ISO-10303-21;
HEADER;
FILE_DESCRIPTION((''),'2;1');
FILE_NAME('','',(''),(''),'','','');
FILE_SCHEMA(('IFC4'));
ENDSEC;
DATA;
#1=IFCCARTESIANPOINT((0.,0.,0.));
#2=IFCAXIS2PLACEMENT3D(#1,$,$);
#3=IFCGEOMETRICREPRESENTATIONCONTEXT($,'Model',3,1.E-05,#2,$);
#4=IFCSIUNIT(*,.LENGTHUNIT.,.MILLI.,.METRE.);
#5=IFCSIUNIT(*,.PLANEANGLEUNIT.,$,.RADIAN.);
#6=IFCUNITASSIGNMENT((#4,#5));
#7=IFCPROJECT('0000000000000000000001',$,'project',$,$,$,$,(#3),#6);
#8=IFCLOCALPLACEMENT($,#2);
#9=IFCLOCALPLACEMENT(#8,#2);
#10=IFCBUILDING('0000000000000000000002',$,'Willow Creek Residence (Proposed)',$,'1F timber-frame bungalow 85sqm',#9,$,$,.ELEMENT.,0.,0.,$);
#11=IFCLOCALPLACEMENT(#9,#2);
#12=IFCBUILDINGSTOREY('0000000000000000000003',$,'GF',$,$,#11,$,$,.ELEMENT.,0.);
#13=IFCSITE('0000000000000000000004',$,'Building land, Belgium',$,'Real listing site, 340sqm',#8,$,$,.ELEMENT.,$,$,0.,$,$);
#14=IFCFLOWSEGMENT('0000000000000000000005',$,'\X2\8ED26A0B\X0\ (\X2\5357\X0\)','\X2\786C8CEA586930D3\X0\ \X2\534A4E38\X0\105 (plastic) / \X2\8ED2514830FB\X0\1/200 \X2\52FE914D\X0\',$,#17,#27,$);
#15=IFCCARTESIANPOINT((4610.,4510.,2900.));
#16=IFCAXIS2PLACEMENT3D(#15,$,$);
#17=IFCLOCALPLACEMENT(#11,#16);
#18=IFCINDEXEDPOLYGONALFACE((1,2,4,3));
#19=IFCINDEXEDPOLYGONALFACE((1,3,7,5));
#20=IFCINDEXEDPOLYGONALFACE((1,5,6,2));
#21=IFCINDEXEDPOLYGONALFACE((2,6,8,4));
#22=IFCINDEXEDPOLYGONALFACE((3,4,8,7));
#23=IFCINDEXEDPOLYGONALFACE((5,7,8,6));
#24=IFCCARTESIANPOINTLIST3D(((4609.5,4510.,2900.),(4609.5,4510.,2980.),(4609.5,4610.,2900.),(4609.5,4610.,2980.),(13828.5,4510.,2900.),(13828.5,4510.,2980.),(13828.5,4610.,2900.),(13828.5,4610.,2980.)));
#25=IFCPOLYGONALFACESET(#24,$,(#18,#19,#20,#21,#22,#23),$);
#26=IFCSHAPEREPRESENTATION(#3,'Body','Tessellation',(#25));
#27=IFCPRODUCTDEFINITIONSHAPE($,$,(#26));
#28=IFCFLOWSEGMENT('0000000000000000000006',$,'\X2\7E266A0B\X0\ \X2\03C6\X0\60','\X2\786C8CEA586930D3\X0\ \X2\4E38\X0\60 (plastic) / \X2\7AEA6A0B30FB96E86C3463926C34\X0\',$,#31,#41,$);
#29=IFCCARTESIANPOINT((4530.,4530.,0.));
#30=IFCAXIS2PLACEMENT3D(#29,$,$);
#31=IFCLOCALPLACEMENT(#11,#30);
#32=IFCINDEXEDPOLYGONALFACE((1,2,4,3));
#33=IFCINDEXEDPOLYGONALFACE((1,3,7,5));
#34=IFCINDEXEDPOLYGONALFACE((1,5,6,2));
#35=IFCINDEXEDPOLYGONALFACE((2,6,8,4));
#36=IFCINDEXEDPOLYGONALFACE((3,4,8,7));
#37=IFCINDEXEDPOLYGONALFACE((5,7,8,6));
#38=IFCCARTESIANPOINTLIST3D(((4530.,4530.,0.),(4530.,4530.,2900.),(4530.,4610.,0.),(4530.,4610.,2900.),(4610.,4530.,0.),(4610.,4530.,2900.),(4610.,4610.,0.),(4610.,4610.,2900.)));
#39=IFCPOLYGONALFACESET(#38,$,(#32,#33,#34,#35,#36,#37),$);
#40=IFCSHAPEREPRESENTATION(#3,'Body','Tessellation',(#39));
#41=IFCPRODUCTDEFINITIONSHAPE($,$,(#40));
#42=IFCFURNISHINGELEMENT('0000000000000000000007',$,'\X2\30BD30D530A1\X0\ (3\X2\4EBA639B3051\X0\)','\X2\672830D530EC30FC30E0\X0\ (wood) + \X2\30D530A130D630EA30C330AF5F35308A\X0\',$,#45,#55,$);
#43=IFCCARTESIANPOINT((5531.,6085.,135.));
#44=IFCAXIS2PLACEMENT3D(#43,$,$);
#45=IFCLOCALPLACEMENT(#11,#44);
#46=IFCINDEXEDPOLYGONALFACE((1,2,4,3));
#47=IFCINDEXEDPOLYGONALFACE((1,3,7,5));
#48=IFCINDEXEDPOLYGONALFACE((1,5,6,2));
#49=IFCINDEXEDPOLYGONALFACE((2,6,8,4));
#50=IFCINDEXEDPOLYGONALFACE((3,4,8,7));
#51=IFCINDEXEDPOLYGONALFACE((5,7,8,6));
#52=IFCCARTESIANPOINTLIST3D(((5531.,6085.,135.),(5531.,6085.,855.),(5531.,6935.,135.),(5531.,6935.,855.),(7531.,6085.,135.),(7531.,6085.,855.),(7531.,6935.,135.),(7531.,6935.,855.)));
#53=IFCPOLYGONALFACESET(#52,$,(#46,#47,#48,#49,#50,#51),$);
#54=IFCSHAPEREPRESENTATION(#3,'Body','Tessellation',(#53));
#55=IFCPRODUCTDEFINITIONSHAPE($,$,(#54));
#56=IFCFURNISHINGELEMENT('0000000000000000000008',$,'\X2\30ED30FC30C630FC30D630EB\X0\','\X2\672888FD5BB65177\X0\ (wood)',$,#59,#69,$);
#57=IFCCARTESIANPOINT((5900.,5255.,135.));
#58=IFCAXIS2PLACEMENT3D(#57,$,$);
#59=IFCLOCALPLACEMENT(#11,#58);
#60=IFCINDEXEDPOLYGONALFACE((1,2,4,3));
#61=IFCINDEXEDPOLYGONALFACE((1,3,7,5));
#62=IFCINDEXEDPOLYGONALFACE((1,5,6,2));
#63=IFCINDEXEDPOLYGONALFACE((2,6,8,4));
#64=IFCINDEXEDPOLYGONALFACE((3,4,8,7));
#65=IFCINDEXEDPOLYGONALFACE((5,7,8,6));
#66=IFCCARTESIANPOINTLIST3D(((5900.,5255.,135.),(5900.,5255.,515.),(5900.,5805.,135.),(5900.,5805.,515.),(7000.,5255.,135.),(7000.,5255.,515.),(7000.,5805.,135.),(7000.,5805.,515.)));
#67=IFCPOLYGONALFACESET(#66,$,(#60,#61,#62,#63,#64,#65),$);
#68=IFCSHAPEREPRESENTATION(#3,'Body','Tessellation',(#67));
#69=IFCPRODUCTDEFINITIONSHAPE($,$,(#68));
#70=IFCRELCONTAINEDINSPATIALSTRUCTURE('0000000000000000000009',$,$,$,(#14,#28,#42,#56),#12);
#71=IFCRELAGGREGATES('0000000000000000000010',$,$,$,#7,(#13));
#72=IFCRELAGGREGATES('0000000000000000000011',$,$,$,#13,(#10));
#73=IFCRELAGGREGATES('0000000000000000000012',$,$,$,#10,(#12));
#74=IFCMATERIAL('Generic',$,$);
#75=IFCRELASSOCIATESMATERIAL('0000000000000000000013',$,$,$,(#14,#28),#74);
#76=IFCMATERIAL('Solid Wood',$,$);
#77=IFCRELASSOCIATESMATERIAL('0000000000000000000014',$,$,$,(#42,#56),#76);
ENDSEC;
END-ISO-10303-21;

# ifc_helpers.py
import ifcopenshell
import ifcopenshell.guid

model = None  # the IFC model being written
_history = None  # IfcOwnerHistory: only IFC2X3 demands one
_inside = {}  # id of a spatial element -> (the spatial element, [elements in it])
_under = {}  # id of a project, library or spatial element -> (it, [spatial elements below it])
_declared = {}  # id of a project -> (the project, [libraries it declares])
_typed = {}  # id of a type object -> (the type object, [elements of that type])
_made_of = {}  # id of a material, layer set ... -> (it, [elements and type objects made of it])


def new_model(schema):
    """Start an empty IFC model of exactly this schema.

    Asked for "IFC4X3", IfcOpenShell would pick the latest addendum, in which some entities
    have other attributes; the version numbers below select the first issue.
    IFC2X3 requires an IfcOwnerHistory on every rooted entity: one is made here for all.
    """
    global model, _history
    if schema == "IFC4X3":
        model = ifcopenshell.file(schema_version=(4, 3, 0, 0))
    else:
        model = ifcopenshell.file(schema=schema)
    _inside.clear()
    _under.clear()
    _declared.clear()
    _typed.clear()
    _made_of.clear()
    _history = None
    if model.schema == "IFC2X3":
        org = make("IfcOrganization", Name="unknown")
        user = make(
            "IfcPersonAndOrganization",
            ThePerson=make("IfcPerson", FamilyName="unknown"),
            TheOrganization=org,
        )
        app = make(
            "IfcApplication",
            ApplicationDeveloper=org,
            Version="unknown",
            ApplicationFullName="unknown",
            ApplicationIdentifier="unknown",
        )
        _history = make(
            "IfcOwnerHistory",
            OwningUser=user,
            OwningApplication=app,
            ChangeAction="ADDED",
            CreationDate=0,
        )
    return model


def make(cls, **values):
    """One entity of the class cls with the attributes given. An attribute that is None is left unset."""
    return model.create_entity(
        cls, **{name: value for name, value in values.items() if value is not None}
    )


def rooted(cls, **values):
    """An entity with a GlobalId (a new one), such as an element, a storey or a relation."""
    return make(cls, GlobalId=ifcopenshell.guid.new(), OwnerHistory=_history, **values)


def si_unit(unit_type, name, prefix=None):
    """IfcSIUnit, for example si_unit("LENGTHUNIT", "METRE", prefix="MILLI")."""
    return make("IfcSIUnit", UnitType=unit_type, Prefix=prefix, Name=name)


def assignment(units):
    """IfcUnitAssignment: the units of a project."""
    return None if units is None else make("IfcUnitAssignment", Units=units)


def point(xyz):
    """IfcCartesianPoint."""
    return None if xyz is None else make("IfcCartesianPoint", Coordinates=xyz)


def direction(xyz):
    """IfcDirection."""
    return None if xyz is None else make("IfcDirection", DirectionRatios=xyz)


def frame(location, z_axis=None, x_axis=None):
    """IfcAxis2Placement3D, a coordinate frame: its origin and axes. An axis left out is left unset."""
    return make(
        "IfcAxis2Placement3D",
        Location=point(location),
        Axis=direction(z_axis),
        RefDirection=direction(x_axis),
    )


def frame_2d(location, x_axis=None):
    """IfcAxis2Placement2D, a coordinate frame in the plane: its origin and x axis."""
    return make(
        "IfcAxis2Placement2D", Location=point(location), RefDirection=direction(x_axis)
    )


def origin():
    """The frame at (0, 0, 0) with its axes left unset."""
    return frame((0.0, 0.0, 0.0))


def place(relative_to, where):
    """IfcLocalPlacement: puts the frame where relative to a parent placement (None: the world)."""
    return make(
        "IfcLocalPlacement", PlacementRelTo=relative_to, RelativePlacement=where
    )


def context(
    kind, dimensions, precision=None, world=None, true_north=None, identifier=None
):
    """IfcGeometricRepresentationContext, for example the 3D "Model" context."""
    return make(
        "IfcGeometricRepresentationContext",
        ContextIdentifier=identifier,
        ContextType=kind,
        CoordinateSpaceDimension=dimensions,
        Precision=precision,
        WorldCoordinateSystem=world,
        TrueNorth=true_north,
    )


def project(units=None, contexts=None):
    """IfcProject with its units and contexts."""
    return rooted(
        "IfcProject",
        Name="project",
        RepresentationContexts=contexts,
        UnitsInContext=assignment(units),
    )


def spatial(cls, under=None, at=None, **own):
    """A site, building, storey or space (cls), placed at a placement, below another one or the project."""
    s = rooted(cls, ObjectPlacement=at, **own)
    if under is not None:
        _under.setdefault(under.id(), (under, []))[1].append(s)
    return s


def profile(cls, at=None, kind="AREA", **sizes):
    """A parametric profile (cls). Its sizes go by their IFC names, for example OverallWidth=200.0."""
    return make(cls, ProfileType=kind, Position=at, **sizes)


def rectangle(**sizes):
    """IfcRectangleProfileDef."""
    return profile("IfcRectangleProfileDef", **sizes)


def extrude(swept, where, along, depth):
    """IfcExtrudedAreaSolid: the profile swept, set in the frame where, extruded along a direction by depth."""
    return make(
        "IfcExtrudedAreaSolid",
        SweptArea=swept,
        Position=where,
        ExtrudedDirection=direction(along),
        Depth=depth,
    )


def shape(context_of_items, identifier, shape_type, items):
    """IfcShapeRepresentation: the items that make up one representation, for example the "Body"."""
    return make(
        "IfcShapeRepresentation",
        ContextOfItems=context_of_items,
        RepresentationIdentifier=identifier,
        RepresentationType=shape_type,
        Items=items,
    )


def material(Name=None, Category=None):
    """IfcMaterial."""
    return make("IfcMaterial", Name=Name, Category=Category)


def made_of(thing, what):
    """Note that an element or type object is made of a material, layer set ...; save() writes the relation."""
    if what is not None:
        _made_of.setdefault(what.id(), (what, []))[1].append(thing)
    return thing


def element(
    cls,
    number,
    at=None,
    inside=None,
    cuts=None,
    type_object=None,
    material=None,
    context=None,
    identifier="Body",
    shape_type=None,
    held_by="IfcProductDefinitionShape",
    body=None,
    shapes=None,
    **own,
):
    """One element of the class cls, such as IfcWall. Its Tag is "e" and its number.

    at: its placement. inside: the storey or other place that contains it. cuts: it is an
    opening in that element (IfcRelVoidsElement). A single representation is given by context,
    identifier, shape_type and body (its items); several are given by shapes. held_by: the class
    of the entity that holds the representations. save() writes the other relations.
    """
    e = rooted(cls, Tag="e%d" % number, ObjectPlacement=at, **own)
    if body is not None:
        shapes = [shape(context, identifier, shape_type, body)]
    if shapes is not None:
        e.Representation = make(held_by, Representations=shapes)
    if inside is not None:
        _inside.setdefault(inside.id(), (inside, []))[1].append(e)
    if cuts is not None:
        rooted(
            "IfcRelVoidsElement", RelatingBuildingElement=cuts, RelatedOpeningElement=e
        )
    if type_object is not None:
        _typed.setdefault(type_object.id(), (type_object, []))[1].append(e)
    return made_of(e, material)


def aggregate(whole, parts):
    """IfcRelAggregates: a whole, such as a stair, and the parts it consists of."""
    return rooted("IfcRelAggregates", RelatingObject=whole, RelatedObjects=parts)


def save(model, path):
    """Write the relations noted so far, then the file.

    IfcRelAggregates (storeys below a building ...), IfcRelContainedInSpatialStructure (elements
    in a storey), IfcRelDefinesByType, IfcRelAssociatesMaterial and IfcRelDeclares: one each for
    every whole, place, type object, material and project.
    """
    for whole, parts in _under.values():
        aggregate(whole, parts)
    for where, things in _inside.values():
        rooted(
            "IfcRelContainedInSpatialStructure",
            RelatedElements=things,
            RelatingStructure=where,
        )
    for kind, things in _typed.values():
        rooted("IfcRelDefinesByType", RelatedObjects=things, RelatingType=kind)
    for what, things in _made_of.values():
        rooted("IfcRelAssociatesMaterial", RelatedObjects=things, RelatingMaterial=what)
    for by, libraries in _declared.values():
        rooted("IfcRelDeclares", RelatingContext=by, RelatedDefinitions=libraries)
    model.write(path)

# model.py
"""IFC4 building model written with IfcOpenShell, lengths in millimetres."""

from ifc_helpers import new_model, si_unit, frame, frame_2d, origin, place, context, project, spatial, rectangle, extrude, material, element, save


model = new_model("IFC4")

# Units and contexts
model_context = context("Model", 3, precision=1e-05, world=origin())
ifc_project = project(units=[si_unit("LENGTHUNIT", "METRE", prefix="MILLI"), si_unit("PLANEANGLEUNIT", "RADIAN")], contexts=[model_context])

# Site, building, storey
site_placement = place(None, origin())
site = spatial("IfcSite", under=ifc_project, at=site_placement, Name="Building land, Belgium", ObjectType="Real listing site, 340sqm", CompositionType="ELEMENT", RefElevation=0.0)
building_placement = place(site_placement, origin())
building = spatial("IfcBuilding", under=site, at=building_placement, Name="Willow Creek Residence (Proposed)", ObjectType="1F timber-frame bungalow 85sqm", CompositionType="ELEMENT", ElevationOfRefHeight=0.0, ElevationOfTerrain=0.0)
storey_placement = place(building_placement, origin())
storey = spatial("IfcBuildingStorey", under=building, at=storey_placement, Name="GF", CompositionType="ELEMENT", Elevation=0.0)

# Shared definitions
ifc_material_1 = material(Name="Solid Wood")

# Shared definitions
ifc_material_2 = material(Name="Generic")

# Flow segments
flow_segment_1_placement = place(storey_placement, frame((4610.0, 4510.0, 2900.0)))
element("IfcFlowSegment", 1, at=flow_segment_1_placement, inside=storey, material=ifc_material_2, Name="軒樋 (南)", Description="硬質塩ビ 半丸105 (plastic) / 軒先・1/200 勾配", context=model_context, shape_type="SweptSolid", body=[
    extrude(rectangle(XDim=9219.0, YDim=100.0, at=frame_2d((4609.0, 50.0))), frame((4610.0, 4510.0, 2900.0)), (0.0, 0.0, 1.0), 80.0),
])
flow_segment_2_placement = place(storey_placement, frame((4530.0, 4530.0, 0.0)))
element("IfcFlowSegment", 2, at=flow_segment_2_placement, inside=storey, material=ifc_material_2, Name="縦樋 φ60", Description="硬質塩ビ 丸60 (plastic) / 竪樋・雨水排水", context=model_context, shape_type="SweptSolid", body=[
    extrude(rectangle(XDim=80.0, YDim=80.0, at=frame_2d((40.0, 40.0))), frame((4530.0, 4530.0, 0.0)), (0.0, 0.0, 1.0), 2900.0),
])

# Furnishing elements
furnishing_1_placement = place(storey_placement, frame((5531.0, 6085.0, 135.0)))
element("IfcFurnishingElement", 3, at=furnishing_1_placement, inside=storey, material=ifc_material_1, Name="ソファ (3人掛け)", Description="木フレーム (wood) + ファブリック張り", context=model_context, shape_type="SweptSolid", body=[
    extrude(rectangle(XDim=2000.0, YDim=850.0, at=frame_2d((1000.0, 425.0))), frame((5531.0, 6085.0, 135.0)), (0.0, 0.0, 1.0), 720.0),
])
furnishing_2_placement = place(storey_placement, frame((5900.0, 5255.0, 135.0)))
element("IfcFurnishingElement", 4, at=furnishing_2_placement, inside=storey, material=ifc_material_1, Name="ローテーブル", Description="木製家具 (wood)", context=model_context, shape_type="SweptSolid", body=[
    extrude(rectangle(XDim=1100.0, YDim=550.0, at=frame_2d((550.0, 275.0))), frame((5900.0, 5255.0, 135.0)), (0.0, 0.0, 1.0), 380.0),
])

save(model, "model.ifc")
